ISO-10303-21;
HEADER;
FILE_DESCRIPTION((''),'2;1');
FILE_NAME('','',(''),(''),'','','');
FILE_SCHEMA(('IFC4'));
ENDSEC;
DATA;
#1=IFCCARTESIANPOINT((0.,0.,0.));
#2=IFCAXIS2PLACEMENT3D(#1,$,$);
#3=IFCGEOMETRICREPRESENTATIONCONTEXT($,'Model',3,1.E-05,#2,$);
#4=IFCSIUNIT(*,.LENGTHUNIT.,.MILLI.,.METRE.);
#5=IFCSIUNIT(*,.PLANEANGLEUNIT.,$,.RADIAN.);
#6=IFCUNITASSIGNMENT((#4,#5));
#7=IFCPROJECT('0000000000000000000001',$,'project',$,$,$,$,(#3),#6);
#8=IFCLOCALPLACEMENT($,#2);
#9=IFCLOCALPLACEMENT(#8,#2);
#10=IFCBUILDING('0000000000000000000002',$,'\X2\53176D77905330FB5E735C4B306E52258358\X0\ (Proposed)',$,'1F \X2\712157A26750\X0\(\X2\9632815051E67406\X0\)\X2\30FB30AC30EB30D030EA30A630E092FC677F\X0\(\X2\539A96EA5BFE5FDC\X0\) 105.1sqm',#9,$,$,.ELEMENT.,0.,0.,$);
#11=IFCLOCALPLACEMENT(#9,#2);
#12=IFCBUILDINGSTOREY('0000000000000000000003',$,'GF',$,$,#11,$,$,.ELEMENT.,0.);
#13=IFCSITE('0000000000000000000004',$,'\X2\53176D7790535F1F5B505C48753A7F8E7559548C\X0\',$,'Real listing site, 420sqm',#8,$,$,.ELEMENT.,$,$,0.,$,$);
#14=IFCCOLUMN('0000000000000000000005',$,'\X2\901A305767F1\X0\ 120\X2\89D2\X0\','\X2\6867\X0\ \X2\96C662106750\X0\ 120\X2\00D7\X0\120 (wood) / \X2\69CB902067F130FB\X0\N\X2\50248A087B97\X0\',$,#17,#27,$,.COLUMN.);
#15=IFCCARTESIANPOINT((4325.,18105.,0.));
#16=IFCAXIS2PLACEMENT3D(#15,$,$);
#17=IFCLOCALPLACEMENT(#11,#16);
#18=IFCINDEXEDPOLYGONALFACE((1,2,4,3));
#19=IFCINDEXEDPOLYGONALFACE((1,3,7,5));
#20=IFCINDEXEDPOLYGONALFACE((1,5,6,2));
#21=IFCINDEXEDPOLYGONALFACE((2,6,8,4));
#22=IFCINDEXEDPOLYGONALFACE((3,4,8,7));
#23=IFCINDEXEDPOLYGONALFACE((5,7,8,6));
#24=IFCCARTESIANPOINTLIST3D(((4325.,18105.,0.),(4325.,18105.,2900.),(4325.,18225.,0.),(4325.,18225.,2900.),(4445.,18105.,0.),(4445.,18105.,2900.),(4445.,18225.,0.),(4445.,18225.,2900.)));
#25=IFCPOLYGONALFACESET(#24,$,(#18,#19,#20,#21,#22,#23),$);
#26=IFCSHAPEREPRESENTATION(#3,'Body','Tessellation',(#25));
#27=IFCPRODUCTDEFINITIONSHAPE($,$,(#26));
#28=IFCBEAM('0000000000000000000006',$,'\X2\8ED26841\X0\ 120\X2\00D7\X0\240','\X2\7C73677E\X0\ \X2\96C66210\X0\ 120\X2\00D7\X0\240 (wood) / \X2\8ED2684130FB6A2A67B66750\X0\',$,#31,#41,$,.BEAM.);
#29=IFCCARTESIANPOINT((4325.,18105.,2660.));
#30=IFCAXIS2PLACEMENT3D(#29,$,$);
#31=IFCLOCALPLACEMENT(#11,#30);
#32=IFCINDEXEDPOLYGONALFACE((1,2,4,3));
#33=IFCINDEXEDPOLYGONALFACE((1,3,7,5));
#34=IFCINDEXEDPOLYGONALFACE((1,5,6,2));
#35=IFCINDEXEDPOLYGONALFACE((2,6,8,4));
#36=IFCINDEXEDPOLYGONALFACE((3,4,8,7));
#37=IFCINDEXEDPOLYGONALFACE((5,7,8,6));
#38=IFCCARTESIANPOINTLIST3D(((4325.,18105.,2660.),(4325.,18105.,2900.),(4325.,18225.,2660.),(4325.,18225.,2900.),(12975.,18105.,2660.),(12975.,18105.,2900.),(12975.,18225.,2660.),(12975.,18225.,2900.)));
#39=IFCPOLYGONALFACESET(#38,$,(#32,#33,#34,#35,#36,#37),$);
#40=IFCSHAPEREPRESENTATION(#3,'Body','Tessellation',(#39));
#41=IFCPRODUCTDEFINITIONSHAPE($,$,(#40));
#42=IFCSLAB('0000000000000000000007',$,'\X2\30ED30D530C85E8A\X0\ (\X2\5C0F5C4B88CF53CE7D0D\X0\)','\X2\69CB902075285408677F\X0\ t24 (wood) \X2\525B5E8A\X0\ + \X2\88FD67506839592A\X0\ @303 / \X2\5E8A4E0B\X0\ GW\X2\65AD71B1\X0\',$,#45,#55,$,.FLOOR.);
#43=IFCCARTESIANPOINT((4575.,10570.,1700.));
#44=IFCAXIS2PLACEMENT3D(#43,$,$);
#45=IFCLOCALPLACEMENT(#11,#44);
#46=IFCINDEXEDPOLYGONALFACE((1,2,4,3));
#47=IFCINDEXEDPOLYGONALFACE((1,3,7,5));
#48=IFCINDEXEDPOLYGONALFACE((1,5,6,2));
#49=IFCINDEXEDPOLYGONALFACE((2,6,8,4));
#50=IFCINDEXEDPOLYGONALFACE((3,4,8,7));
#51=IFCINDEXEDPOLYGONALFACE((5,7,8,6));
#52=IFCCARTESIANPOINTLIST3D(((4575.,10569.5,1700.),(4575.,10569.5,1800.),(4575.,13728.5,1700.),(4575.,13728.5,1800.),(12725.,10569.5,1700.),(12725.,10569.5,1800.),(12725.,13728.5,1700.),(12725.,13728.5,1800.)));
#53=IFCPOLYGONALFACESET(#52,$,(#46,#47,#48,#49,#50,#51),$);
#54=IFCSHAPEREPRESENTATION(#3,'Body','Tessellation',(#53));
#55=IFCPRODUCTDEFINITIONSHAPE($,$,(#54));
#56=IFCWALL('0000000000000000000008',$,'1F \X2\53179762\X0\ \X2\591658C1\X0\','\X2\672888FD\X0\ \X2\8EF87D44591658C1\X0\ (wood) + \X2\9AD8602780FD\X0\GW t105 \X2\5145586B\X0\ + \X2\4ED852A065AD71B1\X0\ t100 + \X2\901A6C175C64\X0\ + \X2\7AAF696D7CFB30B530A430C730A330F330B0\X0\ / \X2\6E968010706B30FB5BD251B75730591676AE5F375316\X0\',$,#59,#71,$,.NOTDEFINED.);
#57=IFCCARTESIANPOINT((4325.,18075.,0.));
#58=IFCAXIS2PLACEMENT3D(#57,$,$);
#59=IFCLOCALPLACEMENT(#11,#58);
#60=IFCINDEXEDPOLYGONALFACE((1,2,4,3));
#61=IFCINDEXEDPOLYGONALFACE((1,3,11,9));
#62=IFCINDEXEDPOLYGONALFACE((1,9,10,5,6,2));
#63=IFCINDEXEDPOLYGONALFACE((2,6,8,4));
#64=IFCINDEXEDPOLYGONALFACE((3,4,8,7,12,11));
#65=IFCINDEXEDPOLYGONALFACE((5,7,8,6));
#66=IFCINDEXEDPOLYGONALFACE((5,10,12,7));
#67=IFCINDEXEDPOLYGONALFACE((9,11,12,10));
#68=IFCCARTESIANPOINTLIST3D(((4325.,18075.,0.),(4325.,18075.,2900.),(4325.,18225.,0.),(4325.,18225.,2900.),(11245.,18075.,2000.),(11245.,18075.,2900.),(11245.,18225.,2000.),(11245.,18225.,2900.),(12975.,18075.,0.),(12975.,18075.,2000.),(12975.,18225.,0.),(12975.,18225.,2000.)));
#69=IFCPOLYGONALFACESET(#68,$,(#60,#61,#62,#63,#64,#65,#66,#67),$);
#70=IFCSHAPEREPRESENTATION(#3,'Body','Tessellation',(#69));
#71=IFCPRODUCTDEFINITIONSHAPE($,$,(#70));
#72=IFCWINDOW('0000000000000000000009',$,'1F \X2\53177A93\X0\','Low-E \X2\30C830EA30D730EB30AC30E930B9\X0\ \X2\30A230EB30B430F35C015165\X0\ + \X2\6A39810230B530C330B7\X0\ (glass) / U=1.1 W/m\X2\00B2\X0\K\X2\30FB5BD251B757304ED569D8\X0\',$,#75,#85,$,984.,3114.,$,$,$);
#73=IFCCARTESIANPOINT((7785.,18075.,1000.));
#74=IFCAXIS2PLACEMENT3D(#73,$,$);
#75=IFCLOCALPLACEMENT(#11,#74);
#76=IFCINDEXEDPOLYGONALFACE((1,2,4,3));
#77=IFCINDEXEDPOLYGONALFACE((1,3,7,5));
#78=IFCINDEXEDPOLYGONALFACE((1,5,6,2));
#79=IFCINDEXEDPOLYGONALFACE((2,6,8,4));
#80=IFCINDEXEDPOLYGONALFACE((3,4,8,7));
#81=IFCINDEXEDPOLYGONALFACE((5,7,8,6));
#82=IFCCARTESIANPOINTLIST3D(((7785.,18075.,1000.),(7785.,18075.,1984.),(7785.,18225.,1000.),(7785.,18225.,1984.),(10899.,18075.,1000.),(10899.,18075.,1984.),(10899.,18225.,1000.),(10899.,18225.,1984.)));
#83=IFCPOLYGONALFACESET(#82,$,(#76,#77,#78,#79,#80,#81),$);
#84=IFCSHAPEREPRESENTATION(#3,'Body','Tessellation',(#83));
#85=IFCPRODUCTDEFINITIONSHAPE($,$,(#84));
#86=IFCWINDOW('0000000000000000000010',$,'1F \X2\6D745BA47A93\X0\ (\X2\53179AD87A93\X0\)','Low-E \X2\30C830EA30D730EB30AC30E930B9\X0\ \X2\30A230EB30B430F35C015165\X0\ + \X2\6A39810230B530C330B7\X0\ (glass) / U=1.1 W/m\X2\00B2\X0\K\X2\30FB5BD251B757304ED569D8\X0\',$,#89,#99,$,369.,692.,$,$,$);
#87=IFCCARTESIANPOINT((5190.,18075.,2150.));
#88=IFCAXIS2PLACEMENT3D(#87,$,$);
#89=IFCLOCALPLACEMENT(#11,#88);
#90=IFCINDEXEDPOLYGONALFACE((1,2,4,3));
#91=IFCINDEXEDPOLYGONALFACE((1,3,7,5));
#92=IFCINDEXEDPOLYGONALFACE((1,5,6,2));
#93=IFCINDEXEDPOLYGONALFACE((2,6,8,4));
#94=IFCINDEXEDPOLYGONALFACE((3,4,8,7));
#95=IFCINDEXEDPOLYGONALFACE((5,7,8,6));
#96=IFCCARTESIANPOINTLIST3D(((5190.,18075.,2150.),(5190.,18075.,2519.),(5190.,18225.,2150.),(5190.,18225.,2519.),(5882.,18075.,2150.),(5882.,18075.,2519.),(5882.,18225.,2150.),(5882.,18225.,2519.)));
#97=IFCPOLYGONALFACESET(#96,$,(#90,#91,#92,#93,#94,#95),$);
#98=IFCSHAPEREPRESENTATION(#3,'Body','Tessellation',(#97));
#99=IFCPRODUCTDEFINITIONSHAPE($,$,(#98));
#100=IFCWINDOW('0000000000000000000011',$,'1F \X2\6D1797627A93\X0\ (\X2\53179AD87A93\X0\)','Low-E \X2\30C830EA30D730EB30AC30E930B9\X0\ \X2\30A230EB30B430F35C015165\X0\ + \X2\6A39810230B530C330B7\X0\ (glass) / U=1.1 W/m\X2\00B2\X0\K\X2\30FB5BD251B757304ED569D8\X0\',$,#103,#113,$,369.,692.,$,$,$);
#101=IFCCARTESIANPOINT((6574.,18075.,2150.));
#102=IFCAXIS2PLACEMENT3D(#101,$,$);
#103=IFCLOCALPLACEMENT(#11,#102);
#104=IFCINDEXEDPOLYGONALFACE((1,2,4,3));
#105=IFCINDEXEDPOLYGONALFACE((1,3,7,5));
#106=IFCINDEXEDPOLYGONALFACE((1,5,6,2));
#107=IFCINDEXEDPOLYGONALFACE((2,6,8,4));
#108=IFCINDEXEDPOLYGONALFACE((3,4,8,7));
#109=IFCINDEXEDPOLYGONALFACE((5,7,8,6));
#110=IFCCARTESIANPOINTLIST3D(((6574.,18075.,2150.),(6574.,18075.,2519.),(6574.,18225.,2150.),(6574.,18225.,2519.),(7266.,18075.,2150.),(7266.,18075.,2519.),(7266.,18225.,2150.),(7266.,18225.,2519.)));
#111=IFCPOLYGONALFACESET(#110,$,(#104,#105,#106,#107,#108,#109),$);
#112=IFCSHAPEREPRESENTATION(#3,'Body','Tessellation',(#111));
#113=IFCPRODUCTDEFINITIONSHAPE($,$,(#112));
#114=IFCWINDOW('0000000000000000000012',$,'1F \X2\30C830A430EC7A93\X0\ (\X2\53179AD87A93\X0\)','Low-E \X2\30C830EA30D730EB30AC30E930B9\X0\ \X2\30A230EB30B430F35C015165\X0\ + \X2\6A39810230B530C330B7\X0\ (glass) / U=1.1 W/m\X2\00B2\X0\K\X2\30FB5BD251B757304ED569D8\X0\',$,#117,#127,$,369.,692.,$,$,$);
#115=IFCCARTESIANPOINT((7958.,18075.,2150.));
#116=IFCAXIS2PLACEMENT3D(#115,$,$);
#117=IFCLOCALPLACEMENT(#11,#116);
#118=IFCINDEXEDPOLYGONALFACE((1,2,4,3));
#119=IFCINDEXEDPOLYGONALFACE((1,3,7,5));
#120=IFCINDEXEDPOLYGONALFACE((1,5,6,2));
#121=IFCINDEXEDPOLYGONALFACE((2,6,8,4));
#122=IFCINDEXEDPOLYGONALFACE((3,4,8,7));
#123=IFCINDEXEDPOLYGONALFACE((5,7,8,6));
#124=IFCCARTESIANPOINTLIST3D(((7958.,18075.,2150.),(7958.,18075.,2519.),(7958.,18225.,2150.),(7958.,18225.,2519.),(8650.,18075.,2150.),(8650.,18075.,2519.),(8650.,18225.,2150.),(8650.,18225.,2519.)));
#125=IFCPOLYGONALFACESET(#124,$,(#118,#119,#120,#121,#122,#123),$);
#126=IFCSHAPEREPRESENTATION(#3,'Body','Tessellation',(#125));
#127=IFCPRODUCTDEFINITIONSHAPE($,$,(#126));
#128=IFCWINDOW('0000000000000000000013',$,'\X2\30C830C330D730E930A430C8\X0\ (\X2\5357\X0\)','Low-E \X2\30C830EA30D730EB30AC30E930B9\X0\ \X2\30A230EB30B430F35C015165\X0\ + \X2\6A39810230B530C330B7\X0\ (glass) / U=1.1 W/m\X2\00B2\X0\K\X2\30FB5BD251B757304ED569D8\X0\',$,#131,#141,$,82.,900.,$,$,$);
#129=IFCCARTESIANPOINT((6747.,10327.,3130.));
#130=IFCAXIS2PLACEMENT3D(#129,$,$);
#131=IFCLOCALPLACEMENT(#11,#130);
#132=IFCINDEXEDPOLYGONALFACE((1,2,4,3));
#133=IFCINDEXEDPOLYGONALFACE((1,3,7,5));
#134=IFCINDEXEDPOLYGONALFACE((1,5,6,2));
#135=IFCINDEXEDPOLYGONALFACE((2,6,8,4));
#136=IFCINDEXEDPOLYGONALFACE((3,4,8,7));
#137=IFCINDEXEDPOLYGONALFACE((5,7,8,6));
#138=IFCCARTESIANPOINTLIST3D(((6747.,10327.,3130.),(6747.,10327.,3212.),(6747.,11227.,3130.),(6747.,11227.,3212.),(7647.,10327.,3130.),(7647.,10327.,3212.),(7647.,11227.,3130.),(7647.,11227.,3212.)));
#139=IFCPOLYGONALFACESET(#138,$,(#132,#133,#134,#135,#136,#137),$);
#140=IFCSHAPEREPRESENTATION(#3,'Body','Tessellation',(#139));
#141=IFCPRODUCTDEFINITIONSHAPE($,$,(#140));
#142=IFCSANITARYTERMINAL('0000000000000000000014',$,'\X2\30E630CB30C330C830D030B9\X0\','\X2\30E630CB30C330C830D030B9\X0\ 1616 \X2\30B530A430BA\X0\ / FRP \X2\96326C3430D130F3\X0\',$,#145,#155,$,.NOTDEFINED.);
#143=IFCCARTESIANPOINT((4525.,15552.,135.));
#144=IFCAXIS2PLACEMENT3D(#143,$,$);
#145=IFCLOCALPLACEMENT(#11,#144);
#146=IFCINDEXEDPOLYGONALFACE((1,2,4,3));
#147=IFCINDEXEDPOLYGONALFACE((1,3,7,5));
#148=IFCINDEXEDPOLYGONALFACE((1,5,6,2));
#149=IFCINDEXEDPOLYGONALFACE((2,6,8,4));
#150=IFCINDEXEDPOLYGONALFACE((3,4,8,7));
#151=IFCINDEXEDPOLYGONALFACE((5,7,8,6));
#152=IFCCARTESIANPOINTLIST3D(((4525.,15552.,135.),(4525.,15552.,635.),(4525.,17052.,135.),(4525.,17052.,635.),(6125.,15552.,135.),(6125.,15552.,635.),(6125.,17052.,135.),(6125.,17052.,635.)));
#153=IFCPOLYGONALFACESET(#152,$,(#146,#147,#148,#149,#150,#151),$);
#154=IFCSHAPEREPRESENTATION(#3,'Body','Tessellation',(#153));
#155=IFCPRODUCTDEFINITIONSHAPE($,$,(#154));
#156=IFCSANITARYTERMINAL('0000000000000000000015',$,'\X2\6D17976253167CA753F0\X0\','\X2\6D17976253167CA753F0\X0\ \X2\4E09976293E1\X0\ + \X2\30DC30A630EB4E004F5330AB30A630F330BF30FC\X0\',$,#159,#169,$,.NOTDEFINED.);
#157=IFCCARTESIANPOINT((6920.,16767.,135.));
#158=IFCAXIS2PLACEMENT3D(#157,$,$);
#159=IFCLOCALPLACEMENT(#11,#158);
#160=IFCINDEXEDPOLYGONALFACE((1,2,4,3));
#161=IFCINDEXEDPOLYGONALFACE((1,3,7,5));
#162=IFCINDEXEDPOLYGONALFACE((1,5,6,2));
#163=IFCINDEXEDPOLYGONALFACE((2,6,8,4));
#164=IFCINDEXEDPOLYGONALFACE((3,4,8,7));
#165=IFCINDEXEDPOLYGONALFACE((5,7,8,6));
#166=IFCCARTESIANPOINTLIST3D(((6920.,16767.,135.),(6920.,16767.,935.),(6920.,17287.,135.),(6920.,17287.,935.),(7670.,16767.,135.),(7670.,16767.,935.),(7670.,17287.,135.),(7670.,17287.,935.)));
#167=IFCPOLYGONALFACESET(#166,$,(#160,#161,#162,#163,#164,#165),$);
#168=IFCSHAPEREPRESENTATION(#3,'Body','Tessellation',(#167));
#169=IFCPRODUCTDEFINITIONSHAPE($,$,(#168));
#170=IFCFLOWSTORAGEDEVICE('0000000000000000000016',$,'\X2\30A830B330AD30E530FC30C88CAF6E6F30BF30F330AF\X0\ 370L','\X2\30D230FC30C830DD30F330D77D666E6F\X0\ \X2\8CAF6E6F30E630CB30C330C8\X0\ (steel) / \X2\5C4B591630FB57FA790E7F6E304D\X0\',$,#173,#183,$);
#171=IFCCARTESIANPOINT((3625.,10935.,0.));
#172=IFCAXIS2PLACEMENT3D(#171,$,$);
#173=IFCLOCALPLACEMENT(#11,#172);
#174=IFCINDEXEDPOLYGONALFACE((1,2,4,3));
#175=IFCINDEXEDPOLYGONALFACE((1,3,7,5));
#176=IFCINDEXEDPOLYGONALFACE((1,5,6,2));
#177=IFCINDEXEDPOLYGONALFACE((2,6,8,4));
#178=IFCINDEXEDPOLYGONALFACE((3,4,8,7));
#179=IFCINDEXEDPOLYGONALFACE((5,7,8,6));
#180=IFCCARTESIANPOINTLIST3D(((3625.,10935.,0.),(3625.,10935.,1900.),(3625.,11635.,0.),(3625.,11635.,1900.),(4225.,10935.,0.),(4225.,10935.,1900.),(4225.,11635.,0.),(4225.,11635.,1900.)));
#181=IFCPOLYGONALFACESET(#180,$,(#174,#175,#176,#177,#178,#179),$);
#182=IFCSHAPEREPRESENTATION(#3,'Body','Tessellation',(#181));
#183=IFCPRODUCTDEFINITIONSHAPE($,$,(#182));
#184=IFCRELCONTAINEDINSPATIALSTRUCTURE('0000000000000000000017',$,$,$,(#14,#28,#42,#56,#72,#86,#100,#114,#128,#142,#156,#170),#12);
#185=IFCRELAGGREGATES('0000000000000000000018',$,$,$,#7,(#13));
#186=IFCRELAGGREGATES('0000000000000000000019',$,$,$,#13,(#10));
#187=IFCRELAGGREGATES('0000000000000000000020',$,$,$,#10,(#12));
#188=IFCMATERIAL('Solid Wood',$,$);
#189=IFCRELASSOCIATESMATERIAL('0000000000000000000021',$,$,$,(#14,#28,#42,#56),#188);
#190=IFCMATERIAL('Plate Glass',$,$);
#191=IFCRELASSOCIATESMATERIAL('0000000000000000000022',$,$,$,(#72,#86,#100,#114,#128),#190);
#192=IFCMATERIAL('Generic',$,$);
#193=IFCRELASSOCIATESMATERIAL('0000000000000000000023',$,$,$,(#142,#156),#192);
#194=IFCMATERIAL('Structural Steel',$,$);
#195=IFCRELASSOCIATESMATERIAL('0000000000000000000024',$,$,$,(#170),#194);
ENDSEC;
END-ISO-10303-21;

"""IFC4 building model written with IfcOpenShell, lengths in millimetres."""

from ifc_helpers import new_model, si_unit, frame, frame_2d, origin, place, context, project, spatial, rectangle, extrude, material, element, fill, save


model = new_model("IFC4")

# Units and contexts
model_context = context("Model", 3, precision=1e-05, world=origin())
ifc_project = project(units=[si_unit("LENGTHUNIT", "METRE", prefix="MILLI"), si_unit("PLANEANGLEUNIT", "RADIAN")], contexts=[model_context])

# Site, building, storey
site_placement = place(None, origin())
site = spatial("IfcSite", under=ifc_project, at=site_placement, Name="北海道弟子屈町美留和", ObjectType="Real listing site, 420sqm", CompositionType="ELEMENT", RefElevation=0.0)
building_placement = place(site_placement, origin())
building = spatial("IfcBuilding", under=site, at=building_placement, Name="北海道・平屋の別荘 (Proposed)", ObjectType="1F 無垢材(防腐処理)・ガルバリウム鋼板(厚雪対応) 105.1sqm", CompositionType="ELEMENT", ElevationOfRefHeight=0.0, ElevationOfTerrain=0.0)
storey_placement = place(building_placement, origin())
storey = spatial("IfcBuildingStorey", under=building, at=storey_placement, Name="GF", CompositionType="ELEMENT", Elevation=0.0)

# Column
ifc_material_1 = material(Name="Solid Wood")
column_1_placement = place(storey_placement, frame((4325.0, 18105.0, 0.0)))
element("IfcColumn", 1, at=column_1_placement, inside=storey, material=ifc_material_1, Name="通し柱 120角", Description="桧 集成材 120×120 (wood) / 構造柱・N値計算", PredefinedType="COLUMN", context=model_context, shape_type="SweptSolid", body=[
    extrude(rectangle(XDim=120.0, YDim=120.0, at=frame_2d((60.0, 60.0))), frame((4325.0, 18105.0, 0.0)), (0.0, 0.0, 1.0), 2900.0),
])

# Beam
beam_1_placement = place(storey_placement, frame((4325.0, 18105.0, 2660.0)))
element("IfcBeam", 2, at=beam_1_placement, inside=storey, material=ifc_material_1, Name="軒桁 120×240", Description="米松 集成 120×240 (wood) / 軒桁・横架材", PredefinedType="BEAM", context=model_context, shape_type="SweptSolid", body=[
    extrude(rectangle(XDim=8650.0, YDim=120.0, at=frame_2d((4325.0, 60.0))), frame((4325.0, 18105.0, 2660.0)), (0.0, 0.0, 1.0), 240.0),
])

# Slab
slab_placement = place(storey_placement, frame((4575.0, 10570.0, 1700.0)))
element("IfcSlab", 3, at=slab_placement, inside=storey, material=ifc_material_1, Name="ロフト床 (小屋裏収納)", Description="構造用合板 t24 (wood) 剛床 + 製材根太 @303 / 床下 GW断熱", PredefinedType="FLOOR", context=model_context, shape_type="SweptSolid", body=[
    extrude(rectangle(XDim=8150.0, YDim=3159.0, at=frame_2d((4075.0, 1579.0))), frame((4575.0, 10570.0, 1700.0)), (0.0, 0.0, 1.0), 100.0),
])

# Wall, openings, windows
wall_1_placement = place(storey_placement, frame((4325.0, 18075.0, 0.0)))
wall_1 = element("IfcWall", 4, at=wall_1_placement, inside=storey, material=ifc_material_1, Name="1F 北面 外壁", Description="木製 軸組外壁 (wood) + 高性能GW t105 充填 + 付加断熱 t100 + 通気層 + 窯業系サイディング / 準耐火・寒冷地外皮強化", PredefinedType="NOTDEFINED", context=model_context, shape_type="SweptSolid", body=[
    extrude(rectangle(XDim=8650.0, YDim=150.0, at=frame_2d((4325.0, 75.0))), frame((4325.0, 18075.0, 0.0)), (0.0, 0.0, 1.0), 2900.0),
])
opening_1_placement = place(storey_placement, frame((7785.0, 18075.0, 1000.0)))
opening_1 = element("IfcOpeningElement", 5, at=opening_1_placement, cuts=wall_1, PredefinedType="NOTDEFINED", context=model_context, shape_type="SweptSolid", body=[
    extrude(rectangle(XDim=3114.0, YDim=150.0, at=frame_2d((1557.0, 75.0))), frame((7785.0, 18075.0, 1000.0)), (0.0, 0.0, 1.0), 984.0),
])
opening_2_placement = place(storey_placement, frame((5190.0, 18075.0, 2150.0)))
opening_2 = element("IfcOpeningElement", 6, at=opening_2_placement, cuts=wall_1, PredefinedType="NOTDEFINED", context=model_context, shape_type="SweptSolid", body=[
    extrude(rectangle(XDim=692.0, YDim=150.0, at=frame_2d((346.0, 75.0))), frame((5190.0, 18075.0, 2150.0)), (0.0, 0.0, 1.0), 369.0),
])
opening_3_placement = place(storey_placement, frame((6574.0, 18075.0, 2150.0)))
opening_3 = element("IfcOpeningElement", 7, at=opening_3_placement, cuts=wall_1, PredefinedType="NOTDEFINED", context=model_context, shape_type="SweptSolid", body=[
    extrude(rectangle(XDim=692.0, YDim=150.0, at=frame_2d((346.0, 75.0))), frame((6574.0, 18075.0, 2150.0)), (0.0, 0.0, 1.0), 369.0),
])
opening_4_placement = place(storey_placement, frame((7958.0, 18075.0, 2150.0)))
opening_4 = element("IfcOpeningElement", 8, at=opening_4_placement, cuts=wall_1, PredefinedType="NOTDEFINED", context=model_context, shape_type="SweptSolid", body=[
    extrude(rectangle(XDim=692.0, YDim=150.0, at=frame_2d((346.0, 75.0))), frame((7958.0, 18075.0, 2150.0)), (0.0, 0.0, 1.0), 369.0),
])
ifc_material_2 = material(Name="Plate Glass")
window_1_placement = place(storey_placement, frame((7785.0, 18075.0, 1000.0)))
window_1 = element("IfcWindow", 9, at=window_1_placement, inside=storey, material=ifc_material_2, Name="1F 北窓", Description="Low-E トリプルガラス アルゴン封入 + 樹脂サッシ (glass) / U=1.1 W/m²K・寒冷地仕様", OverallHeight=984.0, OverallWidth=3114.0, context=model_context, shape_type="SweptSolid", body=[
    extrude(rectangle(XDim=3114.0, YDim=150.0, at=frame_2d((1557.0, 75.0))), frame((7785.0, 18075.0, 1000.0)), (0.0, 0.0, 1.0), 984.0),
])
fill(opening_1, window_1)
window_2_placement = place(storey_placement, frame((5190.0, 18075.0, 2150.0)))
window_2 = element("IfcWindow", 10, at=window_2_placement, inside=storey, material=ifc_material_2, Name="1F 浴室窓 (北高窓)", Description="Low-E トリプルガラス アルゴン封入 + 樹脂サッシ (glass) / U=1.1 W/m²K・寒冷地仕様", OverallHeight=369.0, OverallWidth=692.0, context=model_context, shape_type="SweptSolid", body=[
    extrude(rectangle(XDim=692.0, YDim=150.0, at=frame_2d((346.0, 75.0))), frame((5190.0, 18075.0, 2150.0)), (0.0, 0.0, 1.0), 369.0),
])
fill(opening_2, window_2)
window_3_placement = place(storey_placement, frame((6574.0, 18075.0, 2150.0)))
window_3 = element("IfcWindow", 11, at=window_3_placement, inside=storey, material=ifc_material_2, Name="1F 洗面窓 (北高窓)", Description="Low-E トリプルガラス アルゴン封入 + 樹脂サッシ (glass) / U=1.1 W/m²K・寒冷地仕様", OverallHeight=369.0, OverallWidth=692.0, context=model_context, shape_type="SweptSolid", body=[
    extrude(rectangle(XDim=692.0, YDim=150.0, at=frame_2d((346.0, 75.0))), frame((6574.0, 18075.0, 2150.0)), (0.0, 0.0, 1.0), 369.0),
])
fill(opening_3, window_3)
window_4_placement = place(storey_placement, frame((7958.0, 18075.0, 2150.0)))
window_4 = element("IfcWindow", 12, at=window_4_placement, inside=storey, material=ifc_material_2, Name="1F トイレ窓 (北高窓)", Description="Low-E トリプルガラス アルゴン封入 + 樹脂サッシ (glass) / U=1.1 W/m²K・寒冷地仕様", OverallHeight=369.0, OverallWidth=692.0, context=model_context, shape_type="SweptSolid", body=[
    extrude(rectangle(XDim=692.0, YDim=150.0, at=frame_2d((346.0, 75.0))), frame((7958.0, 18075.0, 2150.0)), (0.0, 0.0, 1.0), 369.0),
])
fill(opening_4, window_4)

# Window
window_5_placement = place(storey_placement, frame((6747.0, 10327.0, 3130.0)))
element("IfcWindow", 13, at=window_5_placement, inside=storey, material=ifc_material_2, Name="トップライト (南)", Description="Low-E トリプルガラス アルゴン封入 + 樹脂サッシ (glass) / U=1.1 W/m²K・寒冷地仕様", OverallHeight=82.0, OverallWidth=900.0, context=model_context, shape_type="SweptSolid", body=[
    extrude(rectangle(XDim=900.0, YDim=900.0, at=frame_2d((450.0, 450.0))), frame((6747.0, 10327.0, 3130.0)), (0.0, 0.0, 1.0), 82.0),
])

# Sanitary terminals
ifc_material_3 = material(Name="Generic")
sanitary_terminal_1_placement = place(storey_placement, frame((4525.0, 15552.0, 135.0)))
element("IfcSanitaryTerminal", 14, at=sanitary_terminal_1_placement, inside=storey, material=ifc_material_3, Name="ユニットバス", Description="ユニットバス 1616 サイズ / FRP 防水パン", PredefinedType="NOTDEFINED", context=model_context, shape_type="SweptSolid", body=[
    extrude(rectangle(XDim=1600.0, YDim=1500.0, at=frame_2d((800.0, 750.0))), frame((4525.0, 15552.0, 135.0)), (0.0, 0.0, 1.0), 500.0),
])
sanitary_terminal_2_placement = place(storey_placement, frame((6920.0, 16767.0, 135.0)))
element("IfcSanitaryTerminal", 15, at=sanitary_terminal_2_placement, inside=storey, material=ifc_material_3, Name="洗面化粧台", Description="洗面化粧台 三面鏡 + ボウル一体カウンター", PredefinedType="NOTDEFINED", context=model_context, shape_type="SweptSolid", body=[
    extrude(rectangle(XDim=750.0, YDim=520.0, at=frame_2d((375.0, 260.0))), frame((6920.0, 16767.0, 135.0)), (0.0, 0.0, 1.0), 800.0),
])

# Flow storage device
ifc_material_4 = material(Name="Structural Steel")
flow_storage_device_placement = place(storey_placement, frame((3625.0, 10935.0, 0.0)))
element("IfcFlowStorageDevice", 16, at=flow_storage_device_placement, inside=storey, material=ifc_material_4, Name="エコキュート貯湯タンク 370L", Description="ヒートポンプ給湯 貯湯ユニット (steel) / 屋外・基礎置き", context=model_context, shape_type="SweptSolid", body=[
    extrude(rectangle(XDim=600.0, YDim=700.0, at=frame_2d((300.0, 350.0))), frame((3625.0, 10935.0, 0.0)), (0.0, 0.0, 1.0), 1900.0),
])

save(model, "model.ifc")
